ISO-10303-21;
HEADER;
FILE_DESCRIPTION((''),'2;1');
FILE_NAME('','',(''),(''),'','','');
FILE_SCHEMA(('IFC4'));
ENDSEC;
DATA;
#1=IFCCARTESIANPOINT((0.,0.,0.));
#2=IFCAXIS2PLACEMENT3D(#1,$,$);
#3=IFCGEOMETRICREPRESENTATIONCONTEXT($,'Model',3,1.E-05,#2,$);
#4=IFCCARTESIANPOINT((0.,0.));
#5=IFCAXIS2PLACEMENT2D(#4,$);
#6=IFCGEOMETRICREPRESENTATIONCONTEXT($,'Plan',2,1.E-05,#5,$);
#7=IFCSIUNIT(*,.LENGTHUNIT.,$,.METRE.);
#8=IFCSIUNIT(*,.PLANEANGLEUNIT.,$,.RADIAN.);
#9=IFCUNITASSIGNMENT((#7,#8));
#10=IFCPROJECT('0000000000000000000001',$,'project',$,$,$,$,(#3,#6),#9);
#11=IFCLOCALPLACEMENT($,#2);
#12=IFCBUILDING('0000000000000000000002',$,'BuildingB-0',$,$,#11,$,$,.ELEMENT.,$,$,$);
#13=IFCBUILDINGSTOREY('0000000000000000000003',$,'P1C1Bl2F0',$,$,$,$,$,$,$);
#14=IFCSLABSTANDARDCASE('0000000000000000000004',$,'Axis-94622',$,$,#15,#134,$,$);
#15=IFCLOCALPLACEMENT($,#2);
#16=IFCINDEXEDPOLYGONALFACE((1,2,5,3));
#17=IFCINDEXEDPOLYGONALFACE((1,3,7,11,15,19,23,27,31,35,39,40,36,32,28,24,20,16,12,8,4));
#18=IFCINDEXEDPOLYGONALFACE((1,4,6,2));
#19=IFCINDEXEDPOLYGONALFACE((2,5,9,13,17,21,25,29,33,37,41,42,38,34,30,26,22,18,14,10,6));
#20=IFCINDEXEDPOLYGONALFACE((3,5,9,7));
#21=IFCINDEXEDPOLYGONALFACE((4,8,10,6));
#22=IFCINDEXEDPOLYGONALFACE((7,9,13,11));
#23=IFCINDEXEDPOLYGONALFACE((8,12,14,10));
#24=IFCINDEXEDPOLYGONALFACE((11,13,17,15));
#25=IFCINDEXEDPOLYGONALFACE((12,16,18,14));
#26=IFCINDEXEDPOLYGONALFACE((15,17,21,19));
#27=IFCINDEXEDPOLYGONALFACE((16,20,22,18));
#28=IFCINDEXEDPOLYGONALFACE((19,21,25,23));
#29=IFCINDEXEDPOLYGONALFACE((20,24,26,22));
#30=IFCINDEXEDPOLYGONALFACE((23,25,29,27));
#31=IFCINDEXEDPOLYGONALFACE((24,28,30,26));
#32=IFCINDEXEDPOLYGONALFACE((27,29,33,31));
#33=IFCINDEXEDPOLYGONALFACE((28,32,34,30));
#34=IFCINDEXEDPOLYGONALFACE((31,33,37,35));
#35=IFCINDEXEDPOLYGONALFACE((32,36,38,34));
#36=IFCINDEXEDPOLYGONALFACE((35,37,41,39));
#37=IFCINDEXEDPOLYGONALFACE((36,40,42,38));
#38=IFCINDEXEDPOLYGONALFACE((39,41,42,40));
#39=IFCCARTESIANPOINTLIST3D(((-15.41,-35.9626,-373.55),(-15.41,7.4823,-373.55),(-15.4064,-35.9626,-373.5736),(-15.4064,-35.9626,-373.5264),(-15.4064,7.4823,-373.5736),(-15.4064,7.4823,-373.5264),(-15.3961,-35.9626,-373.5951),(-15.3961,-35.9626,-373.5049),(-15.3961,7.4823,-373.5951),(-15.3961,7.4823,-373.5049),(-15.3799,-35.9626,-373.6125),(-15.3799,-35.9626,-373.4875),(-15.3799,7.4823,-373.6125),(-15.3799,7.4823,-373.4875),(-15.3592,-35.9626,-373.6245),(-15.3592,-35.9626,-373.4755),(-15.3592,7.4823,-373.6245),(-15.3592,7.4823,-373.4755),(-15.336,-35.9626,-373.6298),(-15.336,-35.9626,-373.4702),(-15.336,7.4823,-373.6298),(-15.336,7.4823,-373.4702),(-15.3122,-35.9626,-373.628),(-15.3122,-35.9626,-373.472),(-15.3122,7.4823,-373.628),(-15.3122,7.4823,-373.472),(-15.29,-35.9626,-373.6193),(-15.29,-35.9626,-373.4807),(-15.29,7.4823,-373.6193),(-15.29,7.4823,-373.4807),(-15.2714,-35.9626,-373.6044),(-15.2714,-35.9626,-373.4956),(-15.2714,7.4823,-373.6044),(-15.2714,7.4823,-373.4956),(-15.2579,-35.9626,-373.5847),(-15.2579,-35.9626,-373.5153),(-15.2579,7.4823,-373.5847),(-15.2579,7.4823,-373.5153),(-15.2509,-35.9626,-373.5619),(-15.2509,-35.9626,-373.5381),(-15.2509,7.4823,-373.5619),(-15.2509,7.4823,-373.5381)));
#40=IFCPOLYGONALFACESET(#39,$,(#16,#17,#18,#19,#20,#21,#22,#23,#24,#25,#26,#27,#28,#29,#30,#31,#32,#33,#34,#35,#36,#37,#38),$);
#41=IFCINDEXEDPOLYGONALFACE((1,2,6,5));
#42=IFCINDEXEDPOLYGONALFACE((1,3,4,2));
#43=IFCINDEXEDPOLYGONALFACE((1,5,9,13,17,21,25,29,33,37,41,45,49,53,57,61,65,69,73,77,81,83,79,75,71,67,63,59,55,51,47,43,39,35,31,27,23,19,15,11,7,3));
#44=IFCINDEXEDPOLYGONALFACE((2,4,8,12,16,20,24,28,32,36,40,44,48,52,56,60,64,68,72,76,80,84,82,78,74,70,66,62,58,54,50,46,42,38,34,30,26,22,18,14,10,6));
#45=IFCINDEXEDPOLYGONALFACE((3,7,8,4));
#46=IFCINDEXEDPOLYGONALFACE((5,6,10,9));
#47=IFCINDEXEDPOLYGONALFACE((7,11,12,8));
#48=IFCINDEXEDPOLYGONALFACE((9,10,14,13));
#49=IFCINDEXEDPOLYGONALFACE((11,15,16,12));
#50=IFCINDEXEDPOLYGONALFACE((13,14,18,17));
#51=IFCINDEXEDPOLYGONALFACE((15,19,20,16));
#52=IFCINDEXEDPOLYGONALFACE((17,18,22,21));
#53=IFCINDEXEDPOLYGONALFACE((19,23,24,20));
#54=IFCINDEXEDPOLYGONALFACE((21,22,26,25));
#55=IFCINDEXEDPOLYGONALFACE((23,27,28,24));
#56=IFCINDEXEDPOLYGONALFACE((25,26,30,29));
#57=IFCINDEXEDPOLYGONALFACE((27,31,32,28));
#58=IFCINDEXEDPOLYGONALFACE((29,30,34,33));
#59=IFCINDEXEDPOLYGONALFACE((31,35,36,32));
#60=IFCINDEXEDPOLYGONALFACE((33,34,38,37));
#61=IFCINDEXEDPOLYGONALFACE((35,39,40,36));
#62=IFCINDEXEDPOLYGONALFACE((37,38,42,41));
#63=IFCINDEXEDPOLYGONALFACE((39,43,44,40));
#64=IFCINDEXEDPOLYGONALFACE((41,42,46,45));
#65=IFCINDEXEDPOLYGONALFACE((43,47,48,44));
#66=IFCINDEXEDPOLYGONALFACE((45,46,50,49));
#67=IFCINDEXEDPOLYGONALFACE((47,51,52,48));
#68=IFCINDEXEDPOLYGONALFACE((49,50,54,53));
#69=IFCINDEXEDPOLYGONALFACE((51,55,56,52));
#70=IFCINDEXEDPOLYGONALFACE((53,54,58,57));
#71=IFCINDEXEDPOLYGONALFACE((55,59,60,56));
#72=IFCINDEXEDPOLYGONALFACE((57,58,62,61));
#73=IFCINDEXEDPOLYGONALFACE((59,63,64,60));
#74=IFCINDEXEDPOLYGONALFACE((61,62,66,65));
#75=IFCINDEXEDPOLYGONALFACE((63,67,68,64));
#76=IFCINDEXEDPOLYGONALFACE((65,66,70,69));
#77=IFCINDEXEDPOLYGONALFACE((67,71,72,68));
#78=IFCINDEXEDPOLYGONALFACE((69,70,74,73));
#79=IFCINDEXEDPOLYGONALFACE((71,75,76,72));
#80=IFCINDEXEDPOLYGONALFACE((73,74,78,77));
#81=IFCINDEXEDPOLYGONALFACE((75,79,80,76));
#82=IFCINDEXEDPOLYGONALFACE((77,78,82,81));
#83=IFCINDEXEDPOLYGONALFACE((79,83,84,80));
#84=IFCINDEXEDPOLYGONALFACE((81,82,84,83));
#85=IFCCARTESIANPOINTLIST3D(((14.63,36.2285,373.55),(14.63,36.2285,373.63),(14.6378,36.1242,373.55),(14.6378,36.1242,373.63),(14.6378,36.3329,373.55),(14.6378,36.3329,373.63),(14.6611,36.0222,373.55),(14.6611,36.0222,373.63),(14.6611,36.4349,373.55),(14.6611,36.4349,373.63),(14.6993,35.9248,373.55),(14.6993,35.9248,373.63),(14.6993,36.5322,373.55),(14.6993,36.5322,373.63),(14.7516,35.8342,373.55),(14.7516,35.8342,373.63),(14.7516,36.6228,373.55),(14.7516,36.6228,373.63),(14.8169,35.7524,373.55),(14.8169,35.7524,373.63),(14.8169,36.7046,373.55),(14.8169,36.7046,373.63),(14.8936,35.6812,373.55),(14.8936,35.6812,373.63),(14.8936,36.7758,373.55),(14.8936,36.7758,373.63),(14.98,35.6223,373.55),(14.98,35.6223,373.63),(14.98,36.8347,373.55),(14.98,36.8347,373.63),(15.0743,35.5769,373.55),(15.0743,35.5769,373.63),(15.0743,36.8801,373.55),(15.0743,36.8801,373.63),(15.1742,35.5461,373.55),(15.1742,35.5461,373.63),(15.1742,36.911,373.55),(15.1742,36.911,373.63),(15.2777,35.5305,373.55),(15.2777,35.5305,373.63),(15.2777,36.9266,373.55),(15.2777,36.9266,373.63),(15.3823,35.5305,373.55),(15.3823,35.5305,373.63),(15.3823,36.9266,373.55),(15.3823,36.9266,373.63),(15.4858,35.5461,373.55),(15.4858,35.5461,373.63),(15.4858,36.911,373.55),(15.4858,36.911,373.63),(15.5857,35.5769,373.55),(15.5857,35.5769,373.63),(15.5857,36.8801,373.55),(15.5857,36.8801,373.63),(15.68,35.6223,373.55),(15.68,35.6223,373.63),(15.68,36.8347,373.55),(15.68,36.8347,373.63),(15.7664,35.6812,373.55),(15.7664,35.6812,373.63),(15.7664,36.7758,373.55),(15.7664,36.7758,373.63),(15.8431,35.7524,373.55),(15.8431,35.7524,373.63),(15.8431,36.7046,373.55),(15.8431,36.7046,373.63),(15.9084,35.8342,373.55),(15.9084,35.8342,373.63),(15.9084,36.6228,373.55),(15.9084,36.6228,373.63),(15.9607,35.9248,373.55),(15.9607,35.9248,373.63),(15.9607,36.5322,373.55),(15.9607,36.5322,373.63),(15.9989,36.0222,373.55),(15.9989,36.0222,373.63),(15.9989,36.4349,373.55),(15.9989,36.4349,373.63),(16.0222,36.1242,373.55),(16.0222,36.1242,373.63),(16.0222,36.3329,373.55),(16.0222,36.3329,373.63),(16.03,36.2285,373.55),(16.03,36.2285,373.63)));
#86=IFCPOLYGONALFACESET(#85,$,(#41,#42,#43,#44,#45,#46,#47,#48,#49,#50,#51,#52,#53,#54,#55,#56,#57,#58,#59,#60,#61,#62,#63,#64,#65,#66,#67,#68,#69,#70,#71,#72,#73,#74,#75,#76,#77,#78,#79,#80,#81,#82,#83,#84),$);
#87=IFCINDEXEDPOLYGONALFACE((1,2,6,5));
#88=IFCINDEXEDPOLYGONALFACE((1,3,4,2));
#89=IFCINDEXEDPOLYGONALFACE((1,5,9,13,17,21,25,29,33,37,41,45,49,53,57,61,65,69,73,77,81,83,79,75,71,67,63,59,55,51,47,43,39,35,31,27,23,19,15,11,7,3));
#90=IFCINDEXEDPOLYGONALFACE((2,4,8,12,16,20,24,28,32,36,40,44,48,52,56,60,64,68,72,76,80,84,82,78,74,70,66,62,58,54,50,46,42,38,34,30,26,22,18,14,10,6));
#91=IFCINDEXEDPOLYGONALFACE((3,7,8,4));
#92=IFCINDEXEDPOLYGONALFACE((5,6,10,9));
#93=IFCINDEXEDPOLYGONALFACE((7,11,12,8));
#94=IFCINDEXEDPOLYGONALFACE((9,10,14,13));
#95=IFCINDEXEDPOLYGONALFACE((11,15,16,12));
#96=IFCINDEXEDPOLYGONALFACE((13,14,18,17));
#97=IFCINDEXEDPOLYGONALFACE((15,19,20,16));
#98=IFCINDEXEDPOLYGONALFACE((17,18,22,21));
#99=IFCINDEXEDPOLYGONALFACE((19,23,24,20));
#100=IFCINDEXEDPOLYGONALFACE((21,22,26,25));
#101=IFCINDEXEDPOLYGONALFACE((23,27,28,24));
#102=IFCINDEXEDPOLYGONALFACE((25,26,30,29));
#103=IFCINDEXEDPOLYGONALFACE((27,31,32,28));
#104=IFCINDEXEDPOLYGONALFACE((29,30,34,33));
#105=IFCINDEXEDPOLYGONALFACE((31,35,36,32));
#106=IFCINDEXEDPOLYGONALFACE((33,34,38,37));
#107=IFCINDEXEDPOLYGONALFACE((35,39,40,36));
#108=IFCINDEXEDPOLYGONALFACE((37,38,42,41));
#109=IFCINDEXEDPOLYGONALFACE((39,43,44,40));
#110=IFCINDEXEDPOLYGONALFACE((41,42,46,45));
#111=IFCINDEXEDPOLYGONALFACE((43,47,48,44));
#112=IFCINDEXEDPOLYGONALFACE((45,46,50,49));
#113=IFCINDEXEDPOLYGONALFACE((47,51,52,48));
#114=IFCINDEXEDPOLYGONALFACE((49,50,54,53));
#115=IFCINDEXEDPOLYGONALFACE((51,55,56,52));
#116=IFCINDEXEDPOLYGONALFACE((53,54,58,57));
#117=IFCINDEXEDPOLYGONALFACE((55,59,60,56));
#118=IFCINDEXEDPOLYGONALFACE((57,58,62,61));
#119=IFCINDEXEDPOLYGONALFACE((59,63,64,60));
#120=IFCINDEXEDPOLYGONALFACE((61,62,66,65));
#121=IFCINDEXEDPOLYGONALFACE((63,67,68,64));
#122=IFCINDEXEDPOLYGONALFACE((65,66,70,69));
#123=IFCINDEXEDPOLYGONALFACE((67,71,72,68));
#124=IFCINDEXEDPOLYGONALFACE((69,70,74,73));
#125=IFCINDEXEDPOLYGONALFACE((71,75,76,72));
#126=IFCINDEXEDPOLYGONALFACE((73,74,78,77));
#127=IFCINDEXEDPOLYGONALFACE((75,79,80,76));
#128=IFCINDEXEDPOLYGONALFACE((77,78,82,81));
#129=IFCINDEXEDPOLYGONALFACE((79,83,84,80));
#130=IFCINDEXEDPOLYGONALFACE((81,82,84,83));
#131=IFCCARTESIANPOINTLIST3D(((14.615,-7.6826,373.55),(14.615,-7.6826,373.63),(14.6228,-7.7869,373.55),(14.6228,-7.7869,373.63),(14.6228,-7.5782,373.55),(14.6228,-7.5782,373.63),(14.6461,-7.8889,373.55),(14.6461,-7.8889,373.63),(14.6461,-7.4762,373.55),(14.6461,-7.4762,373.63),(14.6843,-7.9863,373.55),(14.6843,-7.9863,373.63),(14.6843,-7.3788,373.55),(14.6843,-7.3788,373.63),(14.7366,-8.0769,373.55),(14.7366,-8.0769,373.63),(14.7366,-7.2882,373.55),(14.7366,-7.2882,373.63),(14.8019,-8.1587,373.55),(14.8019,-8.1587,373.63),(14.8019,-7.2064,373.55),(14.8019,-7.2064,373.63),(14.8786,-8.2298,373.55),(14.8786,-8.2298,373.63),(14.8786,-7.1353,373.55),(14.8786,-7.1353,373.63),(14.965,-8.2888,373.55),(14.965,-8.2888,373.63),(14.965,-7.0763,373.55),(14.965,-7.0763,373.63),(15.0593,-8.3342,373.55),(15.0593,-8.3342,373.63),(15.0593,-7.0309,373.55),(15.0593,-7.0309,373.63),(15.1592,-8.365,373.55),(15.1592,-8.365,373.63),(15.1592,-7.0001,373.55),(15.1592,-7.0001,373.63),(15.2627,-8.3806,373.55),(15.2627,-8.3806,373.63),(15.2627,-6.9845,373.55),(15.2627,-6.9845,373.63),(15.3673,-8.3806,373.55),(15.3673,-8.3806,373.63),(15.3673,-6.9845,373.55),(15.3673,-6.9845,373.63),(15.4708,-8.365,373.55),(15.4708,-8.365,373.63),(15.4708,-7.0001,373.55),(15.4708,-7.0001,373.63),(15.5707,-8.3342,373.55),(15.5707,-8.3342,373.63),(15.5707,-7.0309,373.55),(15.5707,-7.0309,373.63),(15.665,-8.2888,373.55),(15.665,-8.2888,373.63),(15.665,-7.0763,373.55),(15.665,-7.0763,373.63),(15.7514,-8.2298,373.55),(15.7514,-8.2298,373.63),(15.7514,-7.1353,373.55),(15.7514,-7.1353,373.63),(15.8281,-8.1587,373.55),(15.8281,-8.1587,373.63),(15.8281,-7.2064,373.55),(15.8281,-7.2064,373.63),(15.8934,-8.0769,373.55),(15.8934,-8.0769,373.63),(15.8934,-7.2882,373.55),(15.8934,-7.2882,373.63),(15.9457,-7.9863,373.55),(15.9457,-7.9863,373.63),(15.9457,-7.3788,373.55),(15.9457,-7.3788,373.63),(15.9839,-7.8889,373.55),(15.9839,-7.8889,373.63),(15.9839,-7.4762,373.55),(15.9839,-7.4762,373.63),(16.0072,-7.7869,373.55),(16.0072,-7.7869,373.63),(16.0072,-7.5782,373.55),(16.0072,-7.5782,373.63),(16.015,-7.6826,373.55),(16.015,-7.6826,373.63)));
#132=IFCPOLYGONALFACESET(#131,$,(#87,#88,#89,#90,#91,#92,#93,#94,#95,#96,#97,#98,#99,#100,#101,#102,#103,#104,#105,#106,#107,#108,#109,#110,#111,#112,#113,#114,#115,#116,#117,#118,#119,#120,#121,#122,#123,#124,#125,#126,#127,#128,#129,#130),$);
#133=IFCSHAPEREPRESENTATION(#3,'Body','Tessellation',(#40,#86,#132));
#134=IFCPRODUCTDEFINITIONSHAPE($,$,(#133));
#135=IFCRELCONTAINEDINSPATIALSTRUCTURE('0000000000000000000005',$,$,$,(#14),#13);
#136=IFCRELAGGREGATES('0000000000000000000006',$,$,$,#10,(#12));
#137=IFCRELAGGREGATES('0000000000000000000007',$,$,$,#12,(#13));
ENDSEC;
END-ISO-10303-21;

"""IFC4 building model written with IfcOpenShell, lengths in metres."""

from ifc_helpers import new_model, entity, si_unit, frame, origin, origin_2d, place, context, project, spatial, circle, extrude, element, save


model = new_model("IFC4")

# Units and contexts
model_context = context("Model", 3, precision=1e-05, world=origin())
plan_context = context("Plan", 2, precision=1e-05, world=origin_2d())
ifc_project = project(units=[si_unit("LENGTHUNIT", "METRE"), si_unit("PLANEANGLEUNIT", "RADIAN")], contexts=[model_context, plan_context])

# Building, storey
building_placement = place(None, origin())
building = spatial("IfcBuilding", under=ifc_project, at=building_placement, Name="BuildingB-0", CompositionType="ELEMENT")
storey = spatial("IfcBuildingStorey", under=building, Name="P1C1Bl2F0")

# Slab
element("IfcSlabStandardCase", 1, inside=storey, Name="Axis-94622", context=model_context, shape_type="AdvancedSweptSolid", body=[
    entity("IfcSurfaceCurveSweptAreaSolid", entity("IfcCircleProfileDef", "AREA", None, None, 0.08), None, entity("IfcPolyline", [entity("IfcCartesianPoint", [15.33, 35.9626, 373.55]), entity("IfcCartesianPoint", [15.33, -7.4823, 373.55])]), None, None, entity("IfcPlane", entity("IfcAxis2Placement3D", entity("IfcCartesianPoint", [15.33, 35.9626, 373.55]), entity("IfcDirection", [0.0, 0.0, 1.0]), entity("IfcDirection", [1.0, 0.0, 0.0])))),
    extrude(circle(Radius=0.7), frame((15.33, 36.2285, 373.55)), (0.0, 0.0, 1.0), 0.08),
    extrude(circle(Radius=0.7), frame((15.315, -7.6826, 373.55)), (0.0, 0.0, 1.0), 0.08),
])

save(model, "model.ifc")
